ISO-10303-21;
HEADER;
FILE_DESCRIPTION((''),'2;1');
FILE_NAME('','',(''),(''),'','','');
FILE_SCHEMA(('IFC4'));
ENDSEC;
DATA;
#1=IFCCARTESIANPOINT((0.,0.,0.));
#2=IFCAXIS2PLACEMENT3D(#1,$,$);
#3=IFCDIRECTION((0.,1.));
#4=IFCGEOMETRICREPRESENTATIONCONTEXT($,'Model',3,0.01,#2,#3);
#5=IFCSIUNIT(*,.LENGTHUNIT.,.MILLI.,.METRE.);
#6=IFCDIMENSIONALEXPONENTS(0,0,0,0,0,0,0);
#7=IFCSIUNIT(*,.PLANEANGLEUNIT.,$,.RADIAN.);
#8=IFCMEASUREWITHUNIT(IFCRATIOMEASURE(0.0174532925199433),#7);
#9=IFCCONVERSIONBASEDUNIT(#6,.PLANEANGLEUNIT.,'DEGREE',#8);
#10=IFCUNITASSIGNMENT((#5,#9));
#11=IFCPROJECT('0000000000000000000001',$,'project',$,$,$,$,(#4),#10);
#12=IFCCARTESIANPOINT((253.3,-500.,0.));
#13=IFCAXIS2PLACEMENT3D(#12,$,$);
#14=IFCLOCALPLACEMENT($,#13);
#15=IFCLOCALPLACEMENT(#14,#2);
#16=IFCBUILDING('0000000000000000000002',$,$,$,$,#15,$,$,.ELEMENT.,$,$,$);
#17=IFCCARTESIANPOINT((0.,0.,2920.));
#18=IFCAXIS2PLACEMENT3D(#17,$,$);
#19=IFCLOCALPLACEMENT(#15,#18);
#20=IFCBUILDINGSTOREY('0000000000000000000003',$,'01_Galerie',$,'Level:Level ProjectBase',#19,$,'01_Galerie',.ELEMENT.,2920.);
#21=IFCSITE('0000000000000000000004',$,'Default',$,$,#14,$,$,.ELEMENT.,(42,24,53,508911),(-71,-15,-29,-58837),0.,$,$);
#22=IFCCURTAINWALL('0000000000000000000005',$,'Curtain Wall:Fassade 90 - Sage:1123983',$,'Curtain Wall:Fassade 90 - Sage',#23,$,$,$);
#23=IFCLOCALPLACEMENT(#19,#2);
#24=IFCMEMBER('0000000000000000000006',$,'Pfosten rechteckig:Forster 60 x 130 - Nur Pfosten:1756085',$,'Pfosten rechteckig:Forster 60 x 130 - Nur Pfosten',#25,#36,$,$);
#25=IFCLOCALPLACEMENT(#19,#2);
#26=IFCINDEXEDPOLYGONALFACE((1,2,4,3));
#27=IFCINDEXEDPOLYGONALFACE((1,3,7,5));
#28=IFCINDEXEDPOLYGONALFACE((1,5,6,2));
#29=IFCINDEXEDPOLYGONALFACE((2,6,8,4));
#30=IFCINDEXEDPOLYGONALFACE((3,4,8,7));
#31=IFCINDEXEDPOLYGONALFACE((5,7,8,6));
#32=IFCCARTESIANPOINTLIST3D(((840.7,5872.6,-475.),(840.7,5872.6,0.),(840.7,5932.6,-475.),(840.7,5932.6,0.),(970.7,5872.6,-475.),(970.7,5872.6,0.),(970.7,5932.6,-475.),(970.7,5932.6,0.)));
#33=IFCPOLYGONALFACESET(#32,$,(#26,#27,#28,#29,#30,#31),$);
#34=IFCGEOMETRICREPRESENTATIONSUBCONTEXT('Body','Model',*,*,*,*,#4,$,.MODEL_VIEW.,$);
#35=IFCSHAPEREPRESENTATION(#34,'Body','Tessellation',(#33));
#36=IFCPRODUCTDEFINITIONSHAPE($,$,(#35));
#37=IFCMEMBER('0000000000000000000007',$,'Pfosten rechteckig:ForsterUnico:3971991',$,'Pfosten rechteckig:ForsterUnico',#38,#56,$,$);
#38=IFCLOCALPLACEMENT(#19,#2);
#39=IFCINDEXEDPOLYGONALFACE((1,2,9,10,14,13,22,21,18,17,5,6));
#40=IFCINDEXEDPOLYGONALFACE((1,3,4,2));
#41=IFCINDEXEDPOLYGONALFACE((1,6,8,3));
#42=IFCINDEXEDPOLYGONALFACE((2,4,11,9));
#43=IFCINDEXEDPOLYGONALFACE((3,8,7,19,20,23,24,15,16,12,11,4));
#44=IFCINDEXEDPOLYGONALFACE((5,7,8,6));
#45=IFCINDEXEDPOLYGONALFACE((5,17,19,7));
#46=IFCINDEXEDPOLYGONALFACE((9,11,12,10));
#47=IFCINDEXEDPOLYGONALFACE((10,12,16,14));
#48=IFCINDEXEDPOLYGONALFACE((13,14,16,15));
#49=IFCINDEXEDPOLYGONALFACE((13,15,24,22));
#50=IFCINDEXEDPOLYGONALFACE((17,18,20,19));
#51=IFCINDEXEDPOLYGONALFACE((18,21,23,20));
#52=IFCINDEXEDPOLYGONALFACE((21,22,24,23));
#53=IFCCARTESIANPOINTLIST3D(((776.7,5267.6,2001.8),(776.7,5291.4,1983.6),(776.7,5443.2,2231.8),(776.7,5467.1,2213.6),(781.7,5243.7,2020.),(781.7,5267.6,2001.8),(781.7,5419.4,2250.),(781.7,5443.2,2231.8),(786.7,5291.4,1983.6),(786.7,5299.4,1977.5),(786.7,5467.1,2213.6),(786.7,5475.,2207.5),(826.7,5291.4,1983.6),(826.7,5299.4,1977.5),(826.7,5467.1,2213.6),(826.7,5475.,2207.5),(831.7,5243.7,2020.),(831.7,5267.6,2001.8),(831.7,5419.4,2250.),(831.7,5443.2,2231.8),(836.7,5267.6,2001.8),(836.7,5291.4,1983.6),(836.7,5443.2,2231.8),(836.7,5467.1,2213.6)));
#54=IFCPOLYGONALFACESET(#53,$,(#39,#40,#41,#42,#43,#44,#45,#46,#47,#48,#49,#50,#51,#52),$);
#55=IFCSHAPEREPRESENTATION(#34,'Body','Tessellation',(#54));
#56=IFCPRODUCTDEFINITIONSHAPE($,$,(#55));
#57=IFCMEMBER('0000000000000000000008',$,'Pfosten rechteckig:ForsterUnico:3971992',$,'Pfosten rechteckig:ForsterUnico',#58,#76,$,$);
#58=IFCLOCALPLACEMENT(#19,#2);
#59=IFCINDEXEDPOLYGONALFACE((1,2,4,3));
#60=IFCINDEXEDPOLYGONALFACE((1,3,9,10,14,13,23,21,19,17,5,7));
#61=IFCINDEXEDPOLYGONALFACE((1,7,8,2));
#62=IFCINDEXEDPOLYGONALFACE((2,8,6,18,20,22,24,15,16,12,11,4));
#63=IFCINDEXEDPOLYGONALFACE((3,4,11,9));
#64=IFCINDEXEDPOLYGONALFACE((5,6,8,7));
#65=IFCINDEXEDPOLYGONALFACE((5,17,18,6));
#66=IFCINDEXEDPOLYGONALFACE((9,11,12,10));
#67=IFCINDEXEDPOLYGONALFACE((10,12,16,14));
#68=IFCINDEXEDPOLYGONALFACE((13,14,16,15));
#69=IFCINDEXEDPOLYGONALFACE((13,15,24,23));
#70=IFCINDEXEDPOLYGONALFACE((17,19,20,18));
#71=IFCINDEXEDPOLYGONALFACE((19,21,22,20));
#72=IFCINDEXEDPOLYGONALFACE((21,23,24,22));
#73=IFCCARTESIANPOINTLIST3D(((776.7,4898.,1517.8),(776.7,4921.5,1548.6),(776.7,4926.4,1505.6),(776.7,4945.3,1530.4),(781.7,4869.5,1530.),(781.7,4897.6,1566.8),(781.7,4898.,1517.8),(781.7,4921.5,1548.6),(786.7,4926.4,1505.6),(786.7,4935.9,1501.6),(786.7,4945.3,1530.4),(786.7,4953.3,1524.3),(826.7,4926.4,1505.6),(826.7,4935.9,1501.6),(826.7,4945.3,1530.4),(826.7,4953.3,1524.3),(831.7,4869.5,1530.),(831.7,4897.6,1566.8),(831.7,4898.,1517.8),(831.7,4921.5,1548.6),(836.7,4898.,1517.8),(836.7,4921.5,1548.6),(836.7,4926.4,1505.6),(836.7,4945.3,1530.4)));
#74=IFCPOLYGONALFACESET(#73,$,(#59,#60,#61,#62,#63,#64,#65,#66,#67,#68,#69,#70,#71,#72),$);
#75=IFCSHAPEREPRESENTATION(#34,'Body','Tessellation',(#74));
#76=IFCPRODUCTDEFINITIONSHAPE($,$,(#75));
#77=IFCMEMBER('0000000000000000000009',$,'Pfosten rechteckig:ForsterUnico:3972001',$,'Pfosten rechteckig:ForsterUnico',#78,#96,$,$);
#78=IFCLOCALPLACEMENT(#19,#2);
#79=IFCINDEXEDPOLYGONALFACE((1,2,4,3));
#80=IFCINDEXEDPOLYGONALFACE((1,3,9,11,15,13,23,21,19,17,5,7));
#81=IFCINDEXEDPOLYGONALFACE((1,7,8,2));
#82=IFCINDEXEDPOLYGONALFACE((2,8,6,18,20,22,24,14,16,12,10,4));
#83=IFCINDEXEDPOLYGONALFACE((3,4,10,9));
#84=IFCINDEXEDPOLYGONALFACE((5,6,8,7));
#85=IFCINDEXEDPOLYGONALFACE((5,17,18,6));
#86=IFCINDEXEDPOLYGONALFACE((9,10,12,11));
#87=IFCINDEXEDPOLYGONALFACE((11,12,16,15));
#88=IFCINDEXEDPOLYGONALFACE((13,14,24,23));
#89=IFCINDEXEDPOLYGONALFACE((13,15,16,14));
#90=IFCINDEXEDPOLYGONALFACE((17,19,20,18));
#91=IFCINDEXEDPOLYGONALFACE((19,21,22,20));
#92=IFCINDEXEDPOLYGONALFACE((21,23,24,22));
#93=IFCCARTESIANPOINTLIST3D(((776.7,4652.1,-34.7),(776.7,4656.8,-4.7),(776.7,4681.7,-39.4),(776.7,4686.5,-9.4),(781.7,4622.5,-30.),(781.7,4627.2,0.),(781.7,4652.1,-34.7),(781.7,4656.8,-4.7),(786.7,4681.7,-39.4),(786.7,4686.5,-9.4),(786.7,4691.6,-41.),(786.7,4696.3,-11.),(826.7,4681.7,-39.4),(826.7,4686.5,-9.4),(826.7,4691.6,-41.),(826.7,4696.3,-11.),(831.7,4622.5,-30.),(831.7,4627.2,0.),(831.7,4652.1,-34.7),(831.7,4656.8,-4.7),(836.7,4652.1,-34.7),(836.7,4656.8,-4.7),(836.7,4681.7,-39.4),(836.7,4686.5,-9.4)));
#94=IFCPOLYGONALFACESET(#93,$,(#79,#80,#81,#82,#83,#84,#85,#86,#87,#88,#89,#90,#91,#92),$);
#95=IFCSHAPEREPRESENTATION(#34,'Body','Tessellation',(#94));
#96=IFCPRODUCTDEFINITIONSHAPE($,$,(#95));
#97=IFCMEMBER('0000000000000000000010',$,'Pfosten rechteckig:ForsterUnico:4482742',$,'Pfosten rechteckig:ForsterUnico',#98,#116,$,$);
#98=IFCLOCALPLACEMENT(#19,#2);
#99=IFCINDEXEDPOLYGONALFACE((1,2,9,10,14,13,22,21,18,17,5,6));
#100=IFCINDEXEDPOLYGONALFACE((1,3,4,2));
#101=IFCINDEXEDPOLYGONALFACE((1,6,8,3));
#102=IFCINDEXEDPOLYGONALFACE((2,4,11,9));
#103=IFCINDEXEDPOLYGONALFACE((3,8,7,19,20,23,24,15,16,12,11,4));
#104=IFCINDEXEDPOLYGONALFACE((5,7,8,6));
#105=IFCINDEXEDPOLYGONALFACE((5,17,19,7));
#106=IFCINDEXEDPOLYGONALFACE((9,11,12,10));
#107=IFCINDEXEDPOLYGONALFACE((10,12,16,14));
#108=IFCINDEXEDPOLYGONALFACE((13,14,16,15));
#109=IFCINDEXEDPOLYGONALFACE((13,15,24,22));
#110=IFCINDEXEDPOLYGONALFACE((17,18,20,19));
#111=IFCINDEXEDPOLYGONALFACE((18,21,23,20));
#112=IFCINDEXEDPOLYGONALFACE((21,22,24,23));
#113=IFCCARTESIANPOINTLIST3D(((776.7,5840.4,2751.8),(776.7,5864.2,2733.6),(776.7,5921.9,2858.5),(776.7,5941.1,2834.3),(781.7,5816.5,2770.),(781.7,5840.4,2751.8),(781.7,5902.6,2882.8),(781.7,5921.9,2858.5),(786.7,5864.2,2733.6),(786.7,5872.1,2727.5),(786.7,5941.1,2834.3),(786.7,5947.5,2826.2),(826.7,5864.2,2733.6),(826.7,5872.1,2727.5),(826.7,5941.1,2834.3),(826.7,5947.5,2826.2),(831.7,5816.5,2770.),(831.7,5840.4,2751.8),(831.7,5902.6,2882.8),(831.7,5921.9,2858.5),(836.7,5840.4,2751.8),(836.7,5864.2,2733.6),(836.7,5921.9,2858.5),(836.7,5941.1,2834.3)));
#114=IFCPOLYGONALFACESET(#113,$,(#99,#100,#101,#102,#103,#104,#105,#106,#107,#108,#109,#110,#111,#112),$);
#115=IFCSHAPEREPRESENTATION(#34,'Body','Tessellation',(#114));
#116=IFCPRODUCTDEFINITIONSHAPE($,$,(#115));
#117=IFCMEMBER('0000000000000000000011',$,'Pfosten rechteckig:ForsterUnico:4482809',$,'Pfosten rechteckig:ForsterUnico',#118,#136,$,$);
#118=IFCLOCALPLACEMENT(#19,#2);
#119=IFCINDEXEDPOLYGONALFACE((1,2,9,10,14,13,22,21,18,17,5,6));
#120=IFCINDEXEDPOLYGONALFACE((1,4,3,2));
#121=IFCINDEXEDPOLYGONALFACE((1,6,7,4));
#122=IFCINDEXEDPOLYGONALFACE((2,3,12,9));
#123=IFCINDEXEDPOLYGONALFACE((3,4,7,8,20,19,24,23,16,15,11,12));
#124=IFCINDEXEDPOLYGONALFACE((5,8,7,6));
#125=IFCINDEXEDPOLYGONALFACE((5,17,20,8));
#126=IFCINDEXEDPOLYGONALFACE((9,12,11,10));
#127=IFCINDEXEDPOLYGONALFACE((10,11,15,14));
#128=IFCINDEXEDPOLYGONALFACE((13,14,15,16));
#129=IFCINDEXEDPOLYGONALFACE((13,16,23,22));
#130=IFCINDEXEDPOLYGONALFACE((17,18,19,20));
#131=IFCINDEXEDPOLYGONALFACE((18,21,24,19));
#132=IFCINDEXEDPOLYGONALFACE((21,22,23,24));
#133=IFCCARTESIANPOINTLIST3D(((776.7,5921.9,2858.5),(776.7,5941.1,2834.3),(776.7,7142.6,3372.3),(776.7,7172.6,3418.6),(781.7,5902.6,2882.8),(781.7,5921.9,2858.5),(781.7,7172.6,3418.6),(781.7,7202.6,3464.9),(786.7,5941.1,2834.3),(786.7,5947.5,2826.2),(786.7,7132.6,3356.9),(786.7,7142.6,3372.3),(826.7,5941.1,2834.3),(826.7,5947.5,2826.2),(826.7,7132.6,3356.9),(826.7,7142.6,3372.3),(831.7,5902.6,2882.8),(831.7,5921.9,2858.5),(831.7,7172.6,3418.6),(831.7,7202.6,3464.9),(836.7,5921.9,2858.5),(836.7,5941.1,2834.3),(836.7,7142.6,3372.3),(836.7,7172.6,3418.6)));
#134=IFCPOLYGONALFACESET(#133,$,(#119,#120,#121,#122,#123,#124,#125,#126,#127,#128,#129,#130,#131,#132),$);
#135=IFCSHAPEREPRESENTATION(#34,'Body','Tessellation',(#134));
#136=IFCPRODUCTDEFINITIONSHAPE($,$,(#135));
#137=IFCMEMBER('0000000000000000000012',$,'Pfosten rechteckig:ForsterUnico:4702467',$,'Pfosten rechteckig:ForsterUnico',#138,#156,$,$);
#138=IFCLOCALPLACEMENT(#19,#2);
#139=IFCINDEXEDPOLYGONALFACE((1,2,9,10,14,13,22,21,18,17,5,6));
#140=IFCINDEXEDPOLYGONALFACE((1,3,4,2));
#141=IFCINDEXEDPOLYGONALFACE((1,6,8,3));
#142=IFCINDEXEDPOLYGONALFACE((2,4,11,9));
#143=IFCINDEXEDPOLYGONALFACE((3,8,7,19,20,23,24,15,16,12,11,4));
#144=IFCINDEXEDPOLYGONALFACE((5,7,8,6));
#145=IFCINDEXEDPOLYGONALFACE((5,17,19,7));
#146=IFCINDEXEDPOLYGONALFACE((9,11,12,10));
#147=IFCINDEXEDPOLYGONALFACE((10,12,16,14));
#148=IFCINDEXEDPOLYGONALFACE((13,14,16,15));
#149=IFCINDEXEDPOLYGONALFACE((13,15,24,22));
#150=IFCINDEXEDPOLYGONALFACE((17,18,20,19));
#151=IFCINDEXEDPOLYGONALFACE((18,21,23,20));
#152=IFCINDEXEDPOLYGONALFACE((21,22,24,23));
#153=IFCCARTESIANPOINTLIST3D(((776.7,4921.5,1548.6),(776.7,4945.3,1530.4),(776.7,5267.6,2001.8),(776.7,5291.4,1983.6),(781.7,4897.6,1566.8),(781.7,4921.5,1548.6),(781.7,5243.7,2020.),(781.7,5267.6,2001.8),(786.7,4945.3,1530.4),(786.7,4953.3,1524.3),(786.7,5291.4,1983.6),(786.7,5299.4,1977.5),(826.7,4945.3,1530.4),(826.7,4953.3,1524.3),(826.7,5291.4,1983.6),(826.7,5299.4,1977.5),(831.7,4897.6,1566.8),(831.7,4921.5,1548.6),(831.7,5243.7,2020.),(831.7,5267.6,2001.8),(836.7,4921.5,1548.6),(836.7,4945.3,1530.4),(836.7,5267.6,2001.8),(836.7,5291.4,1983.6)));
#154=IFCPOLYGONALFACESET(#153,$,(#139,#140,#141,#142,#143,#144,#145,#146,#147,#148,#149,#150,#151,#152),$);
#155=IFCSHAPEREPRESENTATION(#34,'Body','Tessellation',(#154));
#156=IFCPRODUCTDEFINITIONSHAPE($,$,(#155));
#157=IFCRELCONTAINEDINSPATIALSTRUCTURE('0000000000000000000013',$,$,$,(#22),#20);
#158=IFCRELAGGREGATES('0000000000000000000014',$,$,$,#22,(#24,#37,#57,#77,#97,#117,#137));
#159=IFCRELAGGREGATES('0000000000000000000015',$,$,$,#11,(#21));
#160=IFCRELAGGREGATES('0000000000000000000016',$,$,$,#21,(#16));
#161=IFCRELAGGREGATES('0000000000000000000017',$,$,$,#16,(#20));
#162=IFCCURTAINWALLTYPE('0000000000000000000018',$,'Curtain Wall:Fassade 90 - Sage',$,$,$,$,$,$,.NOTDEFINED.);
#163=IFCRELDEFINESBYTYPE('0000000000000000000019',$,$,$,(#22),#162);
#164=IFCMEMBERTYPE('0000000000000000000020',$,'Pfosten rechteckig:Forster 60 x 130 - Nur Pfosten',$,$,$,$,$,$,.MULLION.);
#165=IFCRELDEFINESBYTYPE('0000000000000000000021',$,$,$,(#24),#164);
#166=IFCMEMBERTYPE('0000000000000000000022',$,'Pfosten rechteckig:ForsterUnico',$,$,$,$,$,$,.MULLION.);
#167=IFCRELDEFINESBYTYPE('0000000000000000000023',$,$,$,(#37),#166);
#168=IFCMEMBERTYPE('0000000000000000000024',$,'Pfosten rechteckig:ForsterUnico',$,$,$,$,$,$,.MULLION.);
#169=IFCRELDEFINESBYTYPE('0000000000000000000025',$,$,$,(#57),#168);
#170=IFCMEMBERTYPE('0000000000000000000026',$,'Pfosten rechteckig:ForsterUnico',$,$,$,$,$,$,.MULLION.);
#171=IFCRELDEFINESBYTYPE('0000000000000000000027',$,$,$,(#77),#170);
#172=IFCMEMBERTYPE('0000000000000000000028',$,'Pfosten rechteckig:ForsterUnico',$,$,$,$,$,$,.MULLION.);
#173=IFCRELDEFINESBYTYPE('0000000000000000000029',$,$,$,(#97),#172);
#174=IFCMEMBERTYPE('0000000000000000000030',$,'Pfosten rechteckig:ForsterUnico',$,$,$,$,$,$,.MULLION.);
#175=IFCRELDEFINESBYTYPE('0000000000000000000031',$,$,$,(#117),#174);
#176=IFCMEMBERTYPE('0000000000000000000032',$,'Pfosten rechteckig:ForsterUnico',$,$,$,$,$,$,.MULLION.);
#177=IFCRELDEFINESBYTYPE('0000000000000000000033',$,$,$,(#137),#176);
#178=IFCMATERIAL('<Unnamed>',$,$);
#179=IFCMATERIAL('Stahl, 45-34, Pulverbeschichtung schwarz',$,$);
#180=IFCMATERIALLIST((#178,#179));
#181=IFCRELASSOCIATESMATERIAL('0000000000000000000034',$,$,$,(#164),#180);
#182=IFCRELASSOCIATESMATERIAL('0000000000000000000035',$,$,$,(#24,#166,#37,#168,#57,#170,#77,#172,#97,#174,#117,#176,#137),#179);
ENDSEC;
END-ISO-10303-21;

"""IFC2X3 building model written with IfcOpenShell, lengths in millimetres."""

from ifc_helpers import new_model, entity, si_unit, converted_unit, direction, frame, origin, origin_2d_with_axis, place, context, subcontext, project, spatial, polyline, rectangle, outline, extrude, clip, halfspace, source, transform, mapped, material, material_list, type_object, type_shapes, element, aggregate, save


model = new_model("IFC2X3")

# Units and contexts
model_context = context("Model", 3, precision=0.01, world=origin(), true_north=direction((0.0, 1.0)))
body_context = subcontext(model_context, "Body", "Model", "MODEL_VIEW")
ifc_project = project(units=[si_unit("LENGTHUNIT", "METRE", prefix="MILLI"), converted_unit("PLANEANGLEUNIT", "DEGREE", entity("IfcRatioMeasure", 0.0174532925199433), si_unit("PLANEANGLEUNIT", "RADIAN"), dimensions=[0, 0, 0, 0, 0, 0, 0])], contexts=[model_context])

# Site, building, storey
site_placement = place(None, frame((253.3, -500.0, 0.0)))
site = spatial("IfcSite", under=ifc_project, at=site_placement, Name="Default", CompositionType="ELEMENT", RefLatitude=(42, 24, 53, 508911), RefLongitude=(-71, -15, -29, -58837), RefElevation=0.0)
building_placement = place(site_placement, origin())
building = spatial("IfcBuilding", under=site, at=building_placement, CompositionType="ELEMENT")
storey_placement = place(building_placement, frame((0.0, 0.0, 2920.0)))
storey = spatial("IfcBuildingStorey", under=building, at=storey_placement, Name="01_Galerie", ObjectType="Level:Level ProjectBase", LongName="01_Galerie", CompositionType="ELEMENT", Elevation=2920.0)

# Curtain wall, members
curtain_wall_type = type_object("IfcCurtainWallType", Name="Curtain Wall:Fassade 90 - Sage", PredefinedType="NOTDEFINED")
curtain_wall_placement = place(storey_placement, frame((0.0, 0.0, -2920.0)))
curtain_wall = element("IfcCurtainWall", 1, at=curtain_wall_placement, inside=storey, type_object=curtain_wall_type, Name="Curtain Wall:Fassade 90 - Sage:1123983", ObjectType="Curtain Wall:Fassade 90 - Sage")
ifc_material_1 = material(Name="Stahl, 45-34, Pulverbeschichtung schwarz")
ifc_material_2 = material(Name="<Unnamed>")
ifc_material_list_1 = material_list([ifc_material_2, ifc_material_1])
member_type_1 = type_object("IfcMemberType", Name="Pfosten rechteckig:Forster 60 x 130 - Nur Pfosten", PredefinedType="MULLION", material=ifc_material_list_1)
shared_shape_1 = source(origin(), body_context, "Body", "SweptSolid", [
    extrude(rectangle(XDim=130.0, YDim=60.0, at=origin_2d_with_axis()), frame((0.0, -99.0, -475.0), z_axis=(0.0, 0.0, 1.0), x_axis=(0.0, -1.0, 0.0)), (0.0, 0.0, 1.0), 475.0),
])
type_shapes(member_type_1, [shared_shape_1])
member_1_placement = place(storey_placement, frame((806.7, 5902.6, -475.0), z_axis=(0.0, 0.0, -1.0), x_axis=(0.0, -1.0, 0.0)))
member_1 = element("IfcMember", 2, at=member_1_placement, type_object=member_type_1, material=ifc_material_1, Name="Pfosten rechteckig:Forster 60 x 130 - Nur Pfosten:1756085", ObjectType="Pfosten rechteckig:Forster 60 x 130 - Nur Pfosten", context=body_context, shape_type="MappedRepresentation", body=[
    mapped(shared_shape_1, transform((0.0, 0.0, 0.0), scale=1.0)),
])
member_type_2 = type_object("IfcMemberType", Name="Pfosten rechteckig:ForsterUnico", PredefinedType="MULLION", material=ifc_material_1)
shared_shape_2 = source(origin(), body_context, "Body", "SweptSolid", [
    extrude(outline(polyline([(-20.0, -28.3), (20.0, -28.3), (20.0, -18.3), (30.0, -18.3), (30.0, 11.7), (25.0, 11.7), (25.0, 41.7), (-25.0, 41.7), (-25.0, 11.7), (-30.0, 11.7), (-30.0, -18.3), (-20.0, -18.3), (-20.0, -28.3)])), frame((-41.7, 0.0, -289.4), z_axis=(0.0, 0.0, 1.0), x_axis=(0.0, -1.0, 0.0)), (0.0, 0.0, 1.0), 289.4),
])
type_shapes(member_type_2, [shared_shape_2])
member_2_placement = place(storey_placement, frame((806.7, 5243.7, 2020.0), z_axis=(0.0, -0.606939, -0.794748), x_axis=(0.0, -0.794748, 0.606939)))
member_2 = element("IfcMember", 3, at=member_2_placement, type_object=member_type_2, material=ifc_material_1, Name="Pfosten rechteckig:ForsterUnico:3971991", ObjectType="Pfosten rechteckig:ForsterUnico", context=body_context, shape_type="MappedRepresentation", body=[
    mapped(shared_shape_2, transform((0.0, 0.0, 0.0), scale=1.0)),
])
member_type_3 = type_object("IfcMemberType", Name="Pfosten rechteckig:ForsterUnico", PredefinedType="MULLION", material=ifc_material_1)
shared_shape_3 = source(origin(), body_context, "Body", "Clipping", [
    clip(extrude(outline(polyline([(-20.0, -28.3), (20.0, -28.3), (20.0, -18.3), (30.0, -18.3), (30.0, 11.7), (25.0, 11.7), (25.0, 41.7), (-25.0, 41.7), (-25.0, 11.7), (-30.0, 11.7), (-30.0, -18.3), (-20.0, -18.3), (-20.0, -28.3)])), frame((-41.7, 0.0, -46.3), z_axis=(0.0, 0.0, 1.0), x_axis=(0.0, -1.0, 0.0)), (0.0, 0.0, 1.0), 46.3), halfspace(frame((0.0, -304.8, 0.0), z_axis=(-0.245041, 0.0, 0.969513), x_axis=(-0.969513, 0.0, -0.245041)), False)),
])
type_shapes(member_type_3, [shared_shape_3])
member_3_placement = place(storey_placement, frame((806.7, 4869.5, 1530.0), z_axis=(0.0, -0.606939, -0.794748), x_axis=(0.0, -0.794748, 0.606939)))
member_3 = element("IfcMember", 4, at=member_3_placement, type_object=member_type_3, material=ifc_material_1, Name="Pfosten rechteckig:ForsterUnico:3971992", ObjectType="Pfosten rechteckig:ForsterUnico", context=body_context, shape_type="MappedRepresentation", body=[
    mapped(shared_shape_3, transform((0.0, 0.0, 0.0), scale=1.0)),
])
member_type_4 = type_object("IfcMemberType", Name="Pfosten rechteckig:ForsterUnico", PredefinedType="MULLION", material=ifc_material_1)
shared_shape_4 = source(origin(), body_context, "Body", "SweptSolid", [
    extrude(outline(polyline([(-20.0, -28.3), (20.0, -28.3), (20.0, -18.3), (30.0, -18.3), (30.0, 11.7), (25.0, 11.7), (25.0, 41.7), (-25.0, 41.7), (-25.0, 11.7), (-30.0, 11.7), (-30.0, -18.3), (-20.0, -18.3), (-20.0, -28.3)])), frame((-41.7, 0.0, -30.4), z_axis=(0.0, 0.0, 1.0), x_axis=(0.0, -1.0, 0.0)), (0.0, 0.0, 1.0), 30.4),
])
type_shapes(member_type_4, [shared_shape_4])
member_4_placement = place(storey_placement, frame((806.7, 4622.5, -30.0), z_axis=(0.0, -0.156434, -0.987688), x_axis=(0.0, -0.987688, 0.156434)))
member_4 = element("IfcMember", 5, at=member_4_placement, type_object=member_type_4, material=ifc_material_1, Name="Pfosten rechteckig:ForsterUnico:3972001", ObjectType="Pfosten rechteckig:ForsterUnico", context=body_context, shape_type="MappedRepresentation", body=[
    mapped(shared_shape_4, transform((0.0, 0.0, 0.0), scale=1.0)),
])
member_type_5 = type_object("IfcMemberType", Name="Pfosten rechteckig:ForsterUnico", PredefinedType="MULLION", material=ifc_material_1)
shared_shape_5 = source(origin(), body_context, "Body", "Clipping", [
    clip(extrude(outline(polyline([(-20.0, -28.3), (20.0, -28.3), (20.0, -18.3), (30.0, -18.3), (30.0, 11.7), (25.0, 11.7), (25.0, 41.7), (-25.0, 41.7), (-25.0, 11.7), (-30.0, 11.7), (-30.0, -18.3), (-20.0, -18.3), (-20.0, -28.3)])), frame((-41.7, 0.0, -141.9), z_axis=(0.0, 0.0, 1.0), x_axis=(0.0, -1.0, 0.0)), (0.0, 0.0, 1.0), 141.9), halfspace(frame((0.0, -304.8, -141.9), z_axis=(-0.246234, 0.0, -0.969211), x_axis=(-0.969211, 0.0, 0.246234)), False)),
])
type_shapes(member_type_5, [shared_shape_5])
member_5_placement = place(storey_placement, frame((806.7, 5816.5, 2770.0), z_axis=(0.0, -0.606939, -0.794748), x_axis=(0.0, -0.794748, 0.606939)))
member_5 = element("IfcMember", 6, at=member_5_placement, type_object=member_type_5, material=ifc_material_1, Name="Pfosten rechteckig:ForsterUnico:4482742", ObjectType="Pfosten rechteckig:ForsterUnico", context=body_context, shape_type="MappedRepresentation", body=[
    mapped(shared_shape_5, transform((0.0, 0.0, 0.0), scale=1.0)),
])
member_type_6 = type_object("IfcMemberType", Name="Pfosten rechteckig:ForsterUnico", PredefinedType="MULLION", material=ifc_material_1)
shared_shape_6 = source(origin(), body_context, "Body", "Clipping", [
    clip(clip(extrude(outline(polyline([(-20.0, -28.3), (20.0, -28.3), (20.0, -18.3), (30.0, -18.3), (30.0, 11.7), (25.0, 11.7), (25.0, 41.7), (-25.0, 41.7), (-25.0, 11.7), (-30.0, 11.7), (-30.0, -18.3), (-20.0, -18.3), (-20.0, -28.3)])), frame((-41.7, 0.0, -1424.4), z_axis=(0.0, 0.0, 1.0), x_axis=(0.0, -1.0, 0.0)), (0.0, 0.0, 1.0), 1424.4), halfspace(frame((0.0, 0.0, -1424.4), z_axis=(-0.83925, 0.0, -0.543746), x_axis=(-0.543746, 0.0, 0.83925)), False)), halfspace(frame((0.0, -304.8, 0.0), z_axis=(-0.246234, 0.0, 0.969211), x_axis=(-0.969211, 0.0, -0.246234)), False)),
])
type_shapes(member_type_6, [shared_shape_6])
member_6_placement = place(storey_placement, frame((806.7, 5902.6, 2882.8), z_axis=(0.0, -0.912677, -0.408681), x_axis=(0.0, -0.408681, 0.912677)))
member_6 = element("IfcMember", 7, at=member_6_placement, type_object=member_type_6, material=ifc_material_1, Name="Pfosten rechteckig:ForsterUnico:4482809", ObjectType="Pfosten rechteckig:ForsterUnico", context=body_context, shape_type="MappedRepresentation", body=[
    mapped(shared_shape_6, transform((0.0, 0.0, 0.0), scale=1.0)),
])
member_type_7 = type_object("IfcMemberType", Name="Pfosten rechteckig:ForsterUnico", PredefinedType="MULLION", material=ifc_material_1)
shared_shape_7 = source(origin(), body_context, "Body", "SweptSolid", [
    extrude(outline(polyline([(-20.0, -28.3), (20.0, -28.3), (20.0, -18.3), (30.0, -18.3), (30.0, 11.7), (25.0, 11.7), (25.0, 41.7), (-25.0, 41.7), (-25.0, 11.7), (-30.0, 11.7), (-30.0, -18.3), (-20.0, -18.3), (-20.0, -28.3)])), frame((-41.7, 0.0, -570.2), z_axis=(0.0, 0.0, 1.0), x_axis=(0.0, -1.0, 0.0)), (0.0, 0.0, 1.0), 570.2),
])
type_shapes(member_type_7, [shared_shape_7])
member_7_placement = place(storey_placement, frame((806.7, 4897.6, 1566.8), z_axis=(0.0, -0.606939, -0.794748), x_axis=(0.0, -0.794748, 0.606939)))
member_7 = element("IfcMember", 8, at=member_7_placement, type_object=member_type_7, material=ifc_material_1, Name="Pfosten rechteckig:ForsterUnico:4702467", ObjectType="Pfosten rechteckig:ForsterUnico", context=body_context, shape_type="MappedRepresentation", body=[
    mapped(shared_shape_7, transform((0.0, 0.0, 0.0), scale=1.0)),
])
aggregate(curtain_wall, [member_1, member_2, member_3, member_4, member_5, member_6, member_7])

save(model, "model.ifc")
